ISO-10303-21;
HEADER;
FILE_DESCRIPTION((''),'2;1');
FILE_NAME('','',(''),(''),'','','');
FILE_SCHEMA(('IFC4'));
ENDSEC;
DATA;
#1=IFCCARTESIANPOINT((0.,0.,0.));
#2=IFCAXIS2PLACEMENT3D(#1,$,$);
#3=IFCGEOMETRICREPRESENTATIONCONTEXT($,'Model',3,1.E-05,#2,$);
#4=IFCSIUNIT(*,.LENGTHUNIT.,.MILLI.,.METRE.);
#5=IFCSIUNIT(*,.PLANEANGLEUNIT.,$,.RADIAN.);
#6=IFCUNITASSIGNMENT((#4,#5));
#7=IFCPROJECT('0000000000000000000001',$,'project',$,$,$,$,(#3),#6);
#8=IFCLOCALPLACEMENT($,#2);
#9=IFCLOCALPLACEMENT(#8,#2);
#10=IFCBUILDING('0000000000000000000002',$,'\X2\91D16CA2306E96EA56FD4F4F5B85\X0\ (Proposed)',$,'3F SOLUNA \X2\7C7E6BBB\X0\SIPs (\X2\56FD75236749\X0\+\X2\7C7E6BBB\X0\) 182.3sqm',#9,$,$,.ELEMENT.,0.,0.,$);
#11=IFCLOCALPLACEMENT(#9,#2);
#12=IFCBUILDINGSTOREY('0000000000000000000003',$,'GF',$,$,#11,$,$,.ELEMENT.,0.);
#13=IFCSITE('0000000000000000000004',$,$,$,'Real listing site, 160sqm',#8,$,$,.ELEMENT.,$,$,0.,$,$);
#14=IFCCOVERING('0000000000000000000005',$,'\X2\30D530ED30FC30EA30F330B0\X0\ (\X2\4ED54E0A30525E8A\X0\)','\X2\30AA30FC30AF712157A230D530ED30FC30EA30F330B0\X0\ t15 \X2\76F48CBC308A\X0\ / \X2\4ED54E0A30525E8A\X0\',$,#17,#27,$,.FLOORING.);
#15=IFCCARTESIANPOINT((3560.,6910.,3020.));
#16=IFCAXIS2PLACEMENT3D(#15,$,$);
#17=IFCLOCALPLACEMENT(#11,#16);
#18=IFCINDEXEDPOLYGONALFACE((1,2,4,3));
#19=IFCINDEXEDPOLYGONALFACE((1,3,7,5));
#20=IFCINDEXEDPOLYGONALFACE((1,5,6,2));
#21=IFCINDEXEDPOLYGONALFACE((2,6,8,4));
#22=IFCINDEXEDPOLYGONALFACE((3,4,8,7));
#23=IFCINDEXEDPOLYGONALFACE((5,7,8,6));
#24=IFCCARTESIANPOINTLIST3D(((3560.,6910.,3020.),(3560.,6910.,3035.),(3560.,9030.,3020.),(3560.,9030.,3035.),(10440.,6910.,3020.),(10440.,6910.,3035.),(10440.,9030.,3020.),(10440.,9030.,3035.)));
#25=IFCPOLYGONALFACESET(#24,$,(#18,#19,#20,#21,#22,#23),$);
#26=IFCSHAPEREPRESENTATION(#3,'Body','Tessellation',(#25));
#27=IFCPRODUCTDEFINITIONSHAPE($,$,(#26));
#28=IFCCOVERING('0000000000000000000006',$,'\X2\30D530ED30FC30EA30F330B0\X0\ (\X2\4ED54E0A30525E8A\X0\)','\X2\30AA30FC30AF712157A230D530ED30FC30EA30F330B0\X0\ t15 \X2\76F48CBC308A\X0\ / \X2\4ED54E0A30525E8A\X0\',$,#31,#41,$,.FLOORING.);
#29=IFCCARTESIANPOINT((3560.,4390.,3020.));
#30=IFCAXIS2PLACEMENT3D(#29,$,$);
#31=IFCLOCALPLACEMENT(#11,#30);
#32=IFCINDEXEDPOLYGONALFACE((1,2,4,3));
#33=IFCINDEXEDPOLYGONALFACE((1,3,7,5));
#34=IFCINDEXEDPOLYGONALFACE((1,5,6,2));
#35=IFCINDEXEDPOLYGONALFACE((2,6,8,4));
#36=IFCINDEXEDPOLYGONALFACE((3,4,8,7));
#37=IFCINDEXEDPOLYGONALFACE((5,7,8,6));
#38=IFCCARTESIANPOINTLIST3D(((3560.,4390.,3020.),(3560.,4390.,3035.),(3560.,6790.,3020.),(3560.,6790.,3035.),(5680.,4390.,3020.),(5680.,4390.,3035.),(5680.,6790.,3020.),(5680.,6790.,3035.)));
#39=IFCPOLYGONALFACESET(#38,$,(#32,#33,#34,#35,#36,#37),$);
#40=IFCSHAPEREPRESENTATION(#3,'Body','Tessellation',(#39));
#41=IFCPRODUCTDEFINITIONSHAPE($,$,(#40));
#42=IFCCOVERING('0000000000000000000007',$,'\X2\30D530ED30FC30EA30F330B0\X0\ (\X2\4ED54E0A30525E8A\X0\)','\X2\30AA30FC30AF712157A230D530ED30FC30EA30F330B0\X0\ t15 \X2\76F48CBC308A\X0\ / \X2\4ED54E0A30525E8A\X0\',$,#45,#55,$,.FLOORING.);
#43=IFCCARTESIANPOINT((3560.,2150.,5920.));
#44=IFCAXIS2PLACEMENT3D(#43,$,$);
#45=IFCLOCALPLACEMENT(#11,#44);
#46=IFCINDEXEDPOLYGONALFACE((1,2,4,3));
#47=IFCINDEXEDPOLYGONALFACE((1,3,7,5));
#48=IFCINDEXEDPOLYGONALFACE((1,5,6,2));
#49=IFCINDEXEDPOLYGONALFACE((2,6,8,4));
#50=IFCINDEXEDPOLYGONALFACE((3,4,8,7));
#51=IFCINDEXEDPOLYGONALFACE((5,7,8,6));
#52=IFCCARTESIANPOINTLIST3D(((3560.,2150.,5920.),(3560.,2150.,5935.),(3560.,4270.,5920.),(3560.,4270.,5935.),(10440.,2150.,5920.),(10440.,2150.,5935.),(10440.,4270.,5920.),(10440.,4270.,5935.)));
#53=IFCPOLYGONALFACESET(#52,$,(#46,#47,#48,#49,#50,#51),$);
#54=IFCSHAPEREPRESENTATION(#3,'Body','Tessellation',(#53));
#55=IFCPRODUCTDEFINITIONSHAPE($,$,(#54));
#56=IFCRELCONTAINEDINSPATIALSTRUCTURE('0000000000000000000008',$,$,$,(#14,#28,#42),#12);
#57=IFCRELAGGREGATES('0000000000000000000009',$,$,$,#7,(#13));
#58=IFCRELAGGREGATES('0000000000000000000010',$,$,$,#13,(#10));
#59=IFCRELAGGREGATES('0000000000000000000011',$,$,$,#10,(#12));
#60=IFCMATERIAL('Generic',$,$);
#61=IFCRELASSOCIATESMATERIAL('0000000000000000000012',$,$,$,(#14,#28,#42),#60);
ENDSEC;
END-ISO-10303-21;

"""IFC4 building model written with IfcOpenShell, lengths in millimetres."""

from ifc_helpers import new_model, si_unit, frame, frame_2d, origin, place, context, project, spatial, rectangle, extrude, material, element, save


model = new_model("IFC4")

# Units and contexts
model_context = context("Model", 3, precision=1e-05, world=origin())
ifc_project = project(units=[si_unit("LENGTHUNIT", "METRE", prefix="MILLI"), si_unit("PLANEANGLEUNIT", "RADIAN")], contexts=[model_context])

# Site, building, storey
site_placement = place(None, origin())
site = spatial("IfcSite", under=ifc_project, at=site_placement, ObjectType="Real listing site, 160sqm", CompositionType="ELEMENT", RefElevation=0.0)
building_placement = place(site_placement, origin())
building = spatial("IfcBuilding", under=site, at=building_placement, Name="金沢の雪国住宅 (Proposed)", ObjectType="3F SOLUNA 籾殻SIPs (国産杉+籾殻) 182.3sqm", CompositionType="ELEMENT", ElevationOfRefHeight=0.0, ElevationOfTerrain=0.0)
storey_placement = place(building_placement, origin())
storey = spatial("IfcBuildingStorey", under=building, at=storey_placement, Name="GF", CompositionType="ELEMENT", Elevation=0.0)

# Shared definitions
ifc_material_1 = material(Name="Generic")

# Coverings
covering_1_placement = place(storey_placement, frame((3560.0, 6910.0, 3020.0)))
element("IfcCovering", 1, at=covering_1_placement, inside=storey, material=ifc_material_1, Name="フローリング (仕上げ床)", Description="オーク無垢フローリング t15 直貼り / 仕上げ床", PredefinedType="FLOORING", context=model_context, shape_type="SweptSolid", body=[
    extrude(rectangle(XDim=6880.0, YDim=2120.0, at=frame_2d((3440.0, 1060.0))), frame((3560.0, 6910.0, 3020.0)), (0.0, 0.0, 1.0), 15.0),
])
covering_2_placement = place(storey_placement, frame((3560.0, 4390.0, 3020.0)))
element("IfcCovering", 2, at=covering_2_placement, inside=storey, material=ifc_material_1, Name="フローリング (仕上げ床)", Description="オーク無垢フローリング t15 直貼り / 仕上げ床", PredefinedType="FLOORING", context=model_context, shape_type="SweptSolid", body=[
    extrude(rectangle(XDim=2120.0, YDim=2400.0, at=frame_2d((1060.0, 1200.0))), frame((3560.0, 4390.0, 3020.0)), (0.0, 0.0, 1.0), 15.0),
])
covering_3_placement = place(storey_placement, frame((3560.0, 2150.0, 5920.0)))
element("IfcCovering", 3, at=covering_3_placement, inside=storey, material=ifc_material_1, Name="フローリング (仕上げ床)", Description="オーク無垢フローリング t15 直貼り / 仕上げ床", PredefinedType="FLOORING", context=model_context, shape_type="SweptSolid", body=[
    extrude(rectangle(XDim=6880.0, YDim=2120.0, at=frame_2d((3440.0, 1060.0))), frame((3560.0, 2150.0, 5920.0)), (0.0, 0.0, 1.0), 15.0),
])

save(model, "model.ifc")
